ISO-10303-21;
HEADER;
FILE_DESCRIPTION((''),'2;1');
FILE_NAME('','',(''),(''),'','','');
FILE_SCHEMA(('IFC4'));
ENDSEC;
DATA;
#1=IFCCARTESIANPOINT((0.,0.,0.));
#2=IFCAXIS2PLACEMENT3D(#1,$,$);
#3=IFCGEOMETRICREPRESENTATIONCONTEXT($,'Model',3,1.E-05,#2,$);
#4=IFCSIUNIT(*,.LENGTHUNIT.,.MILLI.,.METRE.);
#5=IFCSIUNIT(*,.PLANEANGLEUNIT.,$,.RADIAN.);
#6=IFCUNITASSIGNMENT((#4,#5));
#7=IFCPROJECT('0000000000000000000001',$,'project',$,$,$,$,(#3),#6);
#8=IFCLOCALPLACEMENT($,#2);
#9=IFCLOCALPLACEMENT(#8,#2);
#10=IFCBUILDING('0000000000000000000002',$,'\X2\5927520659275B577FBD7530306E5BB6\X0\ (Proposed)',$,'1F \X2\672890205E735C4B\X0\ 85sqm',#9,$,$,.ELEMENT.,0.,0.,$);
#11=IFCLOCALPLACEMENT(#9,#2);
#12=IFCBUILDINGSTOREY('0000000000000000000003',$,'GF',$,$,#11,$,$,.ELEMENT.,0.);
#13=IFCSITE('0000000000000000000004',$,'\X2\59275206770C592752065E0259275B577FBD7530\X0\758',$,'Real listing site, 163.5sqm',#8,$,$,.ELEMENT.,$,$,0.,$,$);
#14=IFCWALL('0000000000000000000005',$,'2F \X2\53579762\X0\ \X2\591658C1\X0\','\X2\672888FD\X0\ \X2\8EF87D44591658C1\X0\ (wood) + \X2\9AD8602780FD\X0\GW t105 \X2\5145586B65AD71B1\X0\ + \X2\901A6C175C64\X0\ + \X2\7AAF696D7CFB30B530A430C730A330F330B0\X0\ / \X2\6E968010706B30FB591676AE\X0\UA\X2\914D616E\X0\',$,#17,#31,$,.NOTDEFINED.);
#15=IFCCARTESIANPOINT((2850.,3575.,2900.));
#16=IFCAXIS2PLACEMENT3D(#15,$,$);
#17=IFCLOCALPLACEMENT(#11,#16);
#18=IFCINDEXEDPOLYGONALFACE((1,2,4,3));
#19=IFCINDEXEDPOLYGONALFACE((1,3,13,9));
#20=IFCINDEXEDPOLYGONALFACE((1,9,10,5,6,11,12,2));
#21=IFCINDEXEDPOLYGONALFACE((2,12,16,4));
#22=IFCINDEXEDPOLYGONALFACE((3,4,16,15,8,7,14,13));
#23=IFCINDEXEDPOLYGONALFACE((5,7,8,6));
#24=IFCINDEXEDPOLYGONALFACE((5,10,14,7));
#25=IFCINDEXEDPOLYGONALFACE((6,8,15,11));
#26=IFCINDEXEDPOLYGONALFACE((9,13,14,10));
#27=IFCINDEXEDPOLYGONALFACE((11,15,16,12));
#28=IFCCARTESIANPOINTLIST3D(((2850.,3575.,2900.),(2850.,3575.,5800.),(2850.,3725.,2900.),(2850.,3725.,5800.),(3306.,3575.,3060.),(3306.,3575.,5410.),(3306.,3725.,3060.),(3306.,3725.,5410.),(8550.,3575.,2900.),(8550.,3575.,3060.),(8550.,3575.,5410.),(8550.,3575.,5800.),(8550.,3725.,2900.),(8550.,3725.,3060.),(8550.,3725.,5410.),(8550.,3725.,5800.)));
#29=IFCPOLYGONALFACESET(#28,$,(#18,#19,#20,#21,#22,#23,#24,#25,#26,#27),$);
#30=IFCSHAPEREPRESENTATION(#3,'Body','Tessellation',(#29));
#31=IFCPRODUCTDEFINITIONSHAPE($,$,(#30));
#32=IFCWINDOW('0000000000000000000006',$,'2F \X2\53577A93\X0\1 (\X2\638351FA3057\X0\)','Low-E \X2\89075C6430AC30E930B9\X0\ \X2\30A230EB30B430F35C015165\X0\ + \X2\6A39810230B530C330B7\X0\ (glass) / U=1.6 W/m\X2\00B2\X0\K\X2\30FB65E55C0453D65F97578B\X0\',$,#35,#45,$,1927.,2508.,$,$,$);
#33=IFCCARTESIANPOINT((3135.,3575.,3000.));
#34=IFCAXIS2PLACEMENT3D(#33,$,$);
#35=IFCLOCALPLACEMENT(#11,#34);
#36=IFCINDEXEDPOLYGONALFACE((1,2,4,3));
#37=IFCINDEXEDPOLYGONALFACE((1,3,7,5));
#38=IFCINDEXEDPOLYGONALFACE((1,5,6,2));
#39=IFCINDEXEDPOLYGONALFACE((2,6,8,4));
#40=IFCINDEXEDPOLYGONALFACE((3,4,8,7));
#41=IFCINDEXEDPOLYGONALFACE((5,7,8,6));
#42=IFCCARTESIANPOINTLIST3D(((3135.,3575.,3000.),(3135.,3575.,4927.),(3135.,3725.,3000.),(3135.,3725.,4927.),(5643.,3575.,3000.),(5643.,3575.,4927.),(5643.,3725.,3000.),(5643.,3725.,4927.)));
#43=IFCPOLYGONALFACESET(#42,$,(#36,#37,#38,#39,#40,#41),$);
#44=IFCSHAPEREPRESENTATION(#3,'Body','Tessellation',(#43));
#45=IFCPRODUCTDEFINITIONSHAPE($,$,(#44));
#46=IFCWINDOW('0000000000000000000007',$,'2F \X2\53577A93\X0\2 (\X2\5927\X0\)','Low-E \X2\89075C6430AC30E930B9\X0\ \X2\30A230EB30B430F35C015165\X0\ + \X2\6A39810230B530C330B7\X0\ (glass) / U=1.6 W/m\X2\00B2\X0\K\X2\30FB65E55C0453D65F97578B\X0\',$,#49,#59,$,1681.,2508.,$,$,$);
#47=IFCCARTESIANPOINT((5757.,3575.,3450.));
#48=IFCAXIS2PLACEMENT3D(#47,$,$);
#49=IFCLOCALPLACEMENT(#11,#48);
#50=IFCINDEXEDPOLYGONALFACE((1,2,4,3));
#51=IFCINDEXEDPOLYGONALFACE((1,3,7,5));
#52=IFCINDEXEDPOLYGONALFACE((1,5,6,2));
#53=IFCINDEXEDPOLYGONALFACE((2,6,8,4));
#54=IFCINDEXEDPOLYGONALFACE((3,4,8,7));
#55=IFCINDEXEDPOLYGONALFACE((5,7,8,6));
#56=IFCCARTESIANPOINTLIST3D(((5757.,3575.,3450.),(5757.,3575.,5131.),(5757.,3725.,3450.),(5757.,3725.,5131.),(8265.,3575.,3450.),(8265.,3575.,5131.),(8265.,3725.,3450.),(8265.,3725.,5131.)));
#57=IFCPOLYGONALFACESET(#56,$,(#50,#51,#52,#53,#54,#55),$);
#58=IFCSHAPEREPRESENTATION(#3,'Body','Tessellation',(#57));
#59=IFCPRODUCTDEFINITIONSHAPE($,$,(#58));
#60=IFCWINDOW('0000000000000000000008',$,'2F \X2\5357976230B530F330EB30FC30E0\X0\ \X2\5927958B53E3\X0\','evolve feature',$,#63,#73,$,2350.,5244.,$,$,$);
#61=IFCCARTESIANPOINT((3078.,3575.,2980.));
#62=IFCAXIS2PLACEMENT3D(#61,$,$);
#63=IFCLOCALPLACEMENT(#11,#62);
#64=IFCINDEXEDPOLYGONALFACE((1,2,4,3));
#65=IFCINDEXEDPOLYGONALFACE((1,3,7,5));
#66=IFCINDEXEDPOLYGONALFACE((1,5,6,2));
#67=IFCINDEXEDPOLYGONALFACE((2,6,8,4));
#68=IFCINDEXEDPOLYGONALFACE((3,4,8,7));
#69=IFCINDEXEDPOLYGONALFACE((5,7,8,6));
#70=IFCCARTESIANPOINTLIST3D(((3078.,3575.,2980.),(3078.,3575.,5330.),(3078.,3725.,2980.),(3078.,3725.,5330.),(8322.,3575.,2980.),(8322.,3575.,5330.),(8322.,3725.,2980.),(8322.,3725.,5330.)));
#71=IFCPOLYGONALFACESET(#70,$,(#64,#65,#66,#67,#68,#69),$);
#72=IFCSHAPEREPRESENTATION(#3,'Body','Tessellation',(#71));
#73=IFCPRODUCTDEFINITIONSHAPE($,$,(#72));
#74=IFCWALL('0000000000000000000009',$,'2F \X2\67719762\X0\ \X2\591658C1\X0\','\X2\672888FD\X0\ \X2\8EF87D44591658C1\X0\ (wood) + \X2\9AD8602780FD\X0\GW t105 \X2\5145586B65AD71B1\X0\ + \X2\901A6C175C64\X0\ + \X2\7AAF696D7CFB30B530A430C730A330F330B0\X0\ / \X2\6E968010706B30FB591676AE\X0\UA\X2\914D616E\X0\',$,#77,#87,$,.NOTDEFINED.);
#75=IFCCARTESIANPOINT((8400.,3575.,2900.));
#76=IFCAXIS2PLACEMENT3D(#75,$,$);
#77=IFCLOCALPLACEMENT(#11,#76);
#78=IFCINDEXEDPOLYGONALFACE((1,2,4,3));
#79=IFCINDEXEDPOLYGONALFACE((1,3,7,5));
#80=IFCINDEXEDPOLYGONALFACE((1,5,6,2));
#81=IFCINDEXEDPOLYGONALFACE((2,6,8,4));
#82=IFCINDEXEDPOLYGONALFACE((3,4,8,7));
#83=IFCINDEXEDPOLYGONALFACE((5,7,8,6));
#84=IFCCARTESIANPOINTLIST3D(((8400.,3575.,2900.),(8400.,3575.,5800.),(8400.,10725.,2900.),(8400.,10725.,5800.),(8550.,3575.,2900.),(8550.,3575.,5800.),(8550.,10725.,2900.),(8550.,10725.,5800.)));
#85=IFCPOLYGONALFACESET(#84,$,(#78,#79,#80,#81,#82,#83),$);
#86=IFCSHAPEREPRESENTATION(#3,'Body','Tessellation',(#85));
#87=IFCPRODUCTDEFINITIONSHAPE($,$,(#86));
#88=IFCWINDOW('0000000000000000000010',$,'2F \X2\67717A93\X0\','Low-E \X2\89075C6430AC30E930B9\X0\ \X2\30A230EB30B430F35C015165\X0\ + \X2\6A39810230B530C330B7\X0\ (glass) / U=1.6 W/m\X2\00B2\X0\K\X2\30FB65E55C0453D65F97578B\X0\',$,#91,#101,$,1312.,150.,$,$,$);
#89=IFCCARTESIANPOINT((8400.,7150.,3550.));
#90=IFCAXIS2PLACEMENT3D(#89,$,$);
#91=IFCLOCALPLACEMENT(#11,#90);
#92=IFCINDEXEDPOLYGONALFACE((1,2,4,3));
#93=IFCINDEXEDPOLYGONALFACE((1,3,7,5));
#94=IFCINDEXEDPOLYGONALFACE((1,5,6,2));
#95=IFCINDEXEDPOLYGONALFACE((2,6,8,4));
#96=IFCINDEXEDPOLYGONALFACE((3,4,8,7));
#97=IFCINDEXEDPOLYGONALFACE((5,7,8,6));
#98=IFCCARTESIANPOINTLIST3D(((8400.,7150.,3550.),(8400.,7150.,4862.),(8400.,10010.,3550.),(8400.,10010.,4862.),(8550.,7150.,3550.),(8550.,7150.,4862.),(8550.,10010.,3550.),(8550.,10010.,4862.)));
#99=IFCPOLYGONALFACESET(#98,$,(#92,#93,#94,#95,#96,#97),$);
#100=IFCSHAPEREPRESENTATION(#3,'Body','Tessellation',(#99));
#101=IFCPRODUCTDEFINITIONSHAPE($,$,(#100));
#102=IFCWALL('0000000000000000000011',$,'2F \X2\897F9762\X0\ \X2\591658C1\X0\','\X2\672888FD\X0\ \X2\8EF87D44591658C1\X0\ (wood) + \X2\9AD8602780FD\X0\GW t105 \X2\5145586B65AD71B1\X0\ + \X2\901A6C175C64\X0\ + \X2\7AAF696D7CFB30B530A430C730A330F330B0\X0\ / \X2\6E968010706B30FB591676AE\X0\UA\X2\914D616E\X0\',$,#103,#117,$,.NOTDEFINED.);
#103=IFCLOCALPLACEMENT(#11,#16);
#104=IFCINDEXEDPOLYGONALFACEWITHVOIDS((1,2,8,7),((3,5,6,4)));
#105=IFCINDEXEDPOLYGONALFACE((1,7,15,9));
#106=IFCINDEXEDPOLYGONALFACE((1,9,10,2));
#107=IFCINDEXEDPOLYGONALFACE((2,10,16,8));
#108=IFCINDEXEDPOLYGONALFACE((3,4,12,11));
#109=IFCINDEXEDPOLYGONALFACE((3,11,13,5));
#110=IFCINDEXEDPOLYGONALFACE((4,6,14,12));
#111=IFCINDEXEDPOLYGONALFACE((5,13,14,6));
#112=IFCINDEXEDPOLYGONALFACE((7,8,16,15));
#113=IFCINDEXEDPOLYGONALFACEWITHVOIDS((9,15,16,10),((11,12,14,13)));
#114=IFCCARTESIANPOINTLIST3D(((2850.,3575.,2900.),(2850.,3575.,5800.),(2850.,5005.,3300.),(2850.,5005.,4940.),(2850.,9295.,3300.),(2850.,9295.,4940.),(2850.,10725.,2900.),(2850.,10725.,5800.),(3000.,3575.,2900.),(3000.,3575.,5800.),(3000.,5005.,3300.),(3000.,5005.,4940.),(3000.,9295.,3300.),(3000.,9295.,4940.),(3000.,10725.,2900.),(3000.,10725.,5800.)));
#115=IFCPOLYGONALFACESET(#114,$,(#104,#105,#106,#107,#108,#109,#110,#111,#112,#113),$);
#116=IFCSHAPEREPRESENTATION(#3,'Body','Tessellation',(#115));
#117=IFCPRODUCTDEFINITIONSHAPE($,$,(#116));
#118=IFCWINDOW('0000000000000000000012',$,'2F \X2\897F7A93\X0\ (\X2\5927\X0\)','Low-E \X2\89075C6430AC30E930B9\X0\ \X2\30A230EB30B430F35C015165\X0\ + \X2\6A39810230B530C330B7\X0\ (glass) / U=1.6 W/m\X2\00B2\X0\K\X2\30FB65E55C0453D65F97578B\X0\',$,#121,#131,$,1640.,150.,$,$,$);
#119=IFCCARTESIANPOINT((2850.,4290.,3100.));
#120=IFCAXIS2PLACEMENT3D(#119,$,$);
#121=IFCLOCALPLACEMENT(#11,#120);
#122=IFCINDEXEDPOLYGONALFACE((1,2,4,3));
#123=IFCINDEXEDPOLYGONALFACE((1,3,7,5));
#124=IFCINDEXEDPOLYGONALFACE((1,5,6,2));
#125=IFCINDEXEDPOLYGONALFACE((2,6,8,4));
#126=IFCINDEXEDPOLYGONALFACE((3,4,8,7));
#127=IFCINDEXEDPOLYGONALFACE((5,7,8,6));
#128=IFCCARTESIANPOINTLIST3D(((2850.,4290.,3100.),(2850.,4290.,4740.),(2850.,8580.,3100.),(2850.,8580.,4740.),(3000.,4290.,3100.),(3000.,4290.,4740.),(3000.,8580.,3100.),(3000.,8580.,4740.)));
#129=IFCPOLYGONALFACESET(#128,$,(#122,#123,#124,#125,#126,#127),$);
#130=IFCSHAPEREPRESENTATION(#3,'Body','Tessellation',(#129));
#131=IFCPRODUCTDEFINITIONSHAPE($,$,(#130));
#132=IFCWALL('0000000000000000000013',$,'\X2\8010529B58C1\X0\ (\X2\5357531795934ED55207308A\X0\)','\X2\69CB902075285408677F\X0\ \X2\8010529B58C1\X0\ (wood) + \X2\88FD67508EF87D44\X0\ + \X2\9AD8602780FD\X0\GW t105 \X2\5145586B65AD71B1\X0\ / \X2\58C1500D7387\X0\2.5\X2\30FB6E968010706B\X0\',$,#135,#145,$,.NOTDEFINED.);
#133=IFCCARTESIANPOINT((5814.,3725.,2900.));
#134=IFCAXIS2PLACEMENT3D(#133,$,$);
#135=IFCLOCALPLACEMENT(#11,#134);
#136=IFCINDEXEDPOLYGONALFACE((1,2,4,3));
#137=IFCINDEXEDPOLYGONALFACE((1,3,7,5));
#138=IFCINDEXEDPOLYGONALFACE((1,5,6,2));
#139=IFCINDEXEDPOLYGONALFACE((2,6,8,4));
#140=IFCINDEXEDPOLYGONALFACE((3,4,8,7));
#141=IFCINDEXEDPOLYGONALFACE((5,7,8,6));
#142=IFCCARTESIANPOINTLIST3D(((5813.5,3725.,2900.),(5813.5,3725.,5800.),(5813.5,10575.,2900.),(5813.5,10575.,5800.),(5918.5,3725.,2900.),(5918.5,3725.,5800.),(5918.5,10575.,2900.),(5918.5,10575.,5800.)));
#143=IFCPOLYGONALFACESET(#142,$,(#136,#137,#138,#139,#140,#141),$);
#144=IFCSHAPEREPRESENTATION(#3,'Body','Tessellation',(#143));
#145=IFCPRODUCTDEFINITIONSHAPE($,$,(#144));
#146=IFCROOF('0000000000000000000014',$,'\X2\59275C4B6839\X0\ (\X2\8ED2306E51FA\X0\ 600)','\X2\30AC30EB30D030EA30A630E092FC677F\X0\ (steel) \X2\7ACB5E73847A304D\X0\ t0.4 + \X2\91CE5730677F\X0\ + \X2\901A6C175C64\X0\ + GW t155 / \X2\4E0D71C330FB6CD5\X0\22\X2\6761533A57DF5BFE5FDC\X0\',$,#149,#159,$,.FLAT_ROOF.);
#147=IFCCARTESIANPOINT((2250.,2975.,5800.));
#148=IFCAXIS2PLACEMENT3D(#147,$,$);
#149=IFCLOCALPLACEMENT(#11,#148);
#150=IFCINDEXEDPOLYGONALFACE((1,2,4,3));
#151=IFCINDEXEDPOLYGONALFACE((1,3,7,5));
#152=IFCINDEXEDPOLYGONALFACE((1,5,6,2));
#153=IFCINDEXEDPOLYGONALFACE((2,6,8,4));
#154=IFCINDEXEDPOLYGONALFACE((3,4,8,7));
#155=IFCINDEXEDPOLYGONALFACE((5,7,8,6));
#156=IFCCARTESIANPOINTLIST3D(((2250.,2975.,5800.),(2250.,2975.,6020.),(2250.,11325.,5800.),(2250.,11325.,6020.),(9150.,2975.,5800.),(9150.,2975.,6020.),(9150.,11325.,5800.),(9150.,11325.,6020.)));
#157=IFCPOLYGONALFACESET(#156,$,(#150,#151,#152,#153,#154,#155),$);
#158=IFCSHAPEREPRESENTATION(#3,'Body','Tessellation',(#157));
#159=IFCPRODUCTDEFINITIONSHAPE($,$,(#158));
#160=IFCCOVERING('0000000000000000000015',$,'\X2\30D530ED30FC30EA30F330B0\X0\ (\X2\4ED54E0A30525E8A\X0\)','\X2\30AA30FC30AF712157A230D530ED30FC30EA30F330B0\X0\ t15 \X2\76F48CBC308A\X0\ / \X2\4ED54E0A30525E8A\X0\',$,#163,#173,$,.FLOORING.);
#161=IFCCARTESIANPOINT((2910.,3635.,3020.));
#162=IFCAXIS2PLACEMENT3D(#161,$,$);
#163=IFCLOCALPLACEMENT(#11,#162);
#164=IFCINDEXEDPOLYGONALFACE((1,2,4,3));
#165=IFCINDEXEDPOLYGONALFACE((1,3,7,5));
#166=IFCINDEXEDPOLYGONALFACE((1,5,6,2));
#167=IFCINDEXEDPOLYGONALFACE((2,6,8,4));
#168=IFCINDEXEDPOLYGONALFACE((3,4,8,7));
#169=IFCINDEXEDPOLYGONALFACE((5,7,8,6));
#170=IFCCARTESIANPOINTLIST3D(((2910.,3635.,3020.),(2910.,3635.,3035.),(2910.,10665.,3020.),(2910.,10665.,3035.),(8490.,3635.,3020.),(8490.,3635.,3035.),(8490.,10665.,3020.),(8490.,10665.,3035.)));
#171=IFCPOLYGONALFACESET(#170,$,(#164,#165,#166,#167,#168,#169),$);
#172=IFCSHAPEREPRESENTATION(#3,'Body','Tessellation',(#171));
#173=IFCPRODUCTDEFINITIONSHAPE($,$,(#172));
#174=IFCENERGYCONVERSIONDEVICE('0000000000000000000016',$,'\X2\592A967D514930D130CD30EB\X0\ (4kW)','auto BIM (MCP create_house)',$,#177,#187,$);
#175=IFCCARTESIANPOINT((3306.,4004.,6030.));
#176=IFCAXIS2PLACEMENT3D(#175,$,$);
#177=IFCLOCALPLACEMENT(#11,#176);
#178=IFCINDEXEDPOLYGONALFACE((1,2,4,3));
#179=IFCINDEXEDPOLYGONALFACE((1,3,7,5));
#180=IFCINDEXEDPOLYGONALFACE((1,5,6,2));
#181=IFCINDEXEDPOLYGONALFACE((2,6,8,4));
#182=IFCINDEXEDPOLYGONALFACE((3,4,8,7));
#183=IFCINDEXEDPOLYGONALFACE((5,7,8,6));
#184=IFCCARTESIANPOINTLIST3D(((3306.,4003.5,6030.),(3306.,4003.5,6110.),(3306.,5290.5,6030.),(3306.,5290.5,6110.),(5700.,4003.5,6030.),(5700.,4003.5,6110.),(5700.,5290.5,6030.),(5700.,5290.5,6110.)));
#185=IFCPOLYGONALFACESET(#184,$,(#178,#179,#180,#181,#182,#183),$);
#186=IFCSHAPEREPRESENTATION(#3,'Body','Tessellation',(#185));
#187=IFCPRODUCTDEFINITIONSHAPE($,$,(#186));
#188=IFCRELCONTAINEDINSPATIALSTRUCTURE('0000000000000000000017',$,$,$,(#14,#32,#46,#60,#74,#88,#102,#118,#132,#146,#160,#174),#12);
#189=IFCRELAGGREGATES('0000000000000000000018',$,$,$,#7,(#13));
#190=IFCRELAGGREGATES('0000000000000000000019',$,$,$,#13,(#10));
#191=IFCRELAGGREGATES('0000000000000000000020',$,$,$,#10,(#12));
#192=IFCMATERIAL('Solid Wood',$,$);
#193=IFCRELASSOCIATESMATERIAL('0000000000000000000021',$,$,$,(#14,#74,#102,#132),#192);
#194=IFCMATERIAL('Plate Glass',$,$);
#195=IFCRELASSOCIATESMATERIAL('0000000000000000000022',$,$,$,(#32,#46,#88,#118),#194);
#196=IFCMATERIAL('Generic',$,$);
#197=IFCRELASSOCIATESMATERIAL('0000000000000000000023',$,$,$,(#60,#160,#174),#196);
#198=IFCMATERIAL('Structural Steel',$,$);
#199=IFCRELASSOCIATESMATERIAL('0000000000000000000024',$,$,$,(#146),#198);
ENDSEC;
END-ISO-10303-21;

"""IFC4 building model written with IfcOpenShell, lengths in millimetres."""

from ifc_helpers import new_model, si_unit, frame, frame_2d, origin, place, context, project, spatial, rectangle, extrude, material, element, fill, save


model = new_model("IFC4")

# Units and contexts
model_context = context("Model", 3, precision=1e-05, world=origin())
ifc_project = project(units=[si_unit("LENGTHUNIT", "METRE", prefix="MILLI"), si_unit("PLANEANGLEUNIT", "RADIAN")], contexts=[model_context])

# Site, building, storey
site_placement = place(None, origin())
site = spatial("IfcSite", under=ifc_project, at=site_placement, Name="大分県大分市大字羽田758", ObjectType="Real listing site, 163.5sqm", CompositionType="ELEMENT", RefElevation=0.0)
building_placement = place(site_placement, origin())
building = spatial("IfcBuilding", under=site, at=building_placement, Name="大分大字羽田の家 (Proposed)", ObjectType="1F 木造平屋 85sqm", CompositionType="ELEMENT", ElevationOfRefHeight=0.0, ElevationOfTerrain=0.0)
storey_placement = place(building_placement, origin())
storey = spatial("IfcBuildingStorey", under=building, at=storey_placement, Name="GF", CompositionType="ELEMENT", Elevation=0.0)

# Shared definitions
ifc_material_1 = material(Name="Solid Wood")

# Wall, openings, windows
wall_1_placement = place(storey_placement, frame((2850.0, 3575.0, 2900.0)))
wall_1 = element("IfcWall", 1, at=wall_1_placement, inside=storey, material=ifc_material_1, Name="2F 南面 外壁", Description="木製 軸組外壁 (wood) + 高性能GW t105 充填断熱 + 通気層 + 窯業系サイディング / 準耐火・外皮UA配慮", PredefinedType="NOTDEFINED", context=model_context, shape_type="SweptSolid", body=[
    extrude(rectangle(XDim=5700.0, YDim=150.0, at=frame_2d((2850.0, 75.0))), frame((2850.0, 3575.0, 2900.0)), (0.0, 0.0, 1.0), 2900.0),
])
opening_1_placement = place(storey_placement, frame((3135.0, 3575.0, 3000.0)))
opening_1 = element("IfcOpeningElement", 2, at=opening_1_placement, cuts=wall_1, PredefinedType="NOTDEFINED", context=model_context, shape_type="SweptSolid", body=[
    extrude(rectangle(XDim=2508.0, YDim=150.0, at=frame_2d((1254.0, 75.0))), frame((3135.0, 3575.0, 3000.0)), (0.0, 0.0, 1.0), 1927.0),
])
opening_2_placement = place(storey_placement, frame((5757.0, 3575.0, 3450.0)))
opening_2 = element("IfcOpeningElement", 3, at=opening_2_placement, cuts=wall_1, PredefinedType="NOTDEFINED", context=model_context, shape_type="SweptSolid", body=[
    extrude(rectangle(XDim=2508.0, YDim=150.0, at=frame_2d((1254.0, 75.0))), frame((5757.0, 3575.0, 3450.0)), (0.0, 0.0, 1.0), 1681.0),
])
opening_3_placement = place(storey_placement, frame((3078.0, 3575.0, 2980.0)))
opening_3 = element("IfcOpeningElement", 4, at=opening_3_placement, cuts=wall_1, PredefinedType="NOTDEFINED", context=model_context, shape_type="SweptSolid", body=[
    extrude(rectangle(XDim=5244.0, YDim=150.0, at=frame_2d((2622.0, 75.0))), frame((3078.0, 3575.0, 2980.0)), (0.0, 0.0, 1.0), 2350.0),
])
ifc_material_2 = material(Name="Plate Glass")
window_1_placement = place(storey_placement, frame((3135.0, 3575.0, 3000.0)))
window_1 = element("IfcWindow", 5, at=window_1_placement, inside=storey, material=ifc_material_2, Name="2F 南窓1 (掃出し)", Description="Low-E 複層ガラス アルゴン封入 + 樹脂サッシ (glass) / U=1.6 W/m²K・日射取得型", OverallHeight=1927.0, OverallWidth=2508.0, context=model_context, shape_type="SweptSolid", body=[
    extrude(rectangle(XDim=2508.0, YDim=150.0, at=frame_2d((1254.0, 75.0))), frame((3135.0, 3575.0, 3000.0)), (0.0, 0.0, 1.0), 1927.0),
])
fill(opening_1, window_1)
window_2_placement = place(storey_placement, frame((5757.0, 3575.0, 3450.0)))
window_2 = element("IfcWindow", 6, at=window_2_placement, inside=storey, material=ifc_material_2, Name="2F 南窓2 (大)", Description="Low-E 複層ガラス アルゴン封入 + 樹脂サッシ (glass) / U=1.6 W/m²K・日射取得型", OverallHeight=1681.0, OverallWidth=2508.0, context=model_context, shape_type="SweptSolid", body=[
    extrude(rectangle(XDim=2508.0, YDim=150.0, at=frame_2d((1254.0, 75.0))), frame((5757.0, 3575.0, 3450.0)), (0.0, 0.0, 1.0), 1681.0),
])
fill(opening_2, window_2)
ifc_material_3 = material(Name="Generic")
window_3_placement = place(storey_placement, frame((3078.0, 3575.0, 2980.0)))
window_3 = element("IfcWindow", 7, at=window_3_placement, inside=storey, material=ifc_material_3, Name="2F 南面サンルーム 大開口", Description="evolve feature", OverallHeight=2350.0, OverallWidth=5244.0, context=model_context, shape_type="SweptSolid", body=[
    extrude(rectangle(XDim=5244.0, YDim=150.0, at=frame_2d((2622.0, 75.0))), frame((3078.0, 3575.0, 2980.0)), (0.0, 0.0, 1.0), 2350.0),
])
fill(opening_3, window_3)

# Walls, openings, windows
wall_2_placement = place(storey_placement, frame((8400.0, 3575.0, 2900.0)))
wall_2 = element("IfcWall", 8, at=wall_2_placement, inside=storey, material=ifc_material_1, Name="2F 東面 外壁", Description="木製 軸組外壁 (wood) + 高性能GW t105 充填断熱 + 通気層 + 窯業系サイディング / 準耐火・外皮UA配慮", PredefinedType="NOTDEFINED", context=model_context, shape_type="SweptSolid", body=[
    extrude(rectangle(XDim=150.0, YDim=7150.0, at=frame_2d((75.0, 3575.0))), frame((8400.0, 3575.0, 2900.0)), (0.0, 0.0, 1.0), 2900.0),
])
opening_4_placement = place(storey_placement, frame((8400.0, 7150.0, 3550.0)))
opening_4 = element("IfcOpeningElement", 9, at=opening_4_placement, cuts=wall_2, PredefinedType="NOTDEFINED", context=model_context, shape_type="SweptSolid", body=[
    extrude(rectangle(XDim=150.0, YDim=2860.0, at=frame_2d((75.0, 1430.0))), frame((8400.0, 7150.0, 3550.0)), (0.0, 0.0, 1.0), 1312.0),
])
window_4_placement = place(storey_placement, frame((8400.0, 7150.0, 3550.0)))
window_4 = element("IfcWindow", 10, at=window_4_placement, inside=storey, material=ifc_material_2, Name="2F 東窓", Description="Low-E 複層ガラス アルゴン封入 + 樹脂サッシ (glass) / U=1.6 W/m²K・日射取得型", OverallHeight=1312.0, OverallWidth=150.0, context=model_context, shape_type="SweptSolid", body=[
    extrude(rectangle(XDim=150.0, YDim=2860.0, at=frame_2d((75.0, 1430.0))), frame((8400.0, 7150.0, 3550.0)), (0.0, 0.0, 1.0), 1312.0),
])
fill(opening_4, window_4)
wall_3_placement = place(storey_placement, frame((2850.0, 3575.0, 2900.0)))
wall_3 = element("IfcWall", 11, at=wall_3_placement, inside=storey, material=ifc_material_1, Name="2F 西面 外壁", Description="木製 軸組外壁 (wood) + 高性能GW t105 充填断熱 + 通気層 + 窯業系サイディング / 準耐火・外皮UA配慮", PredefinedType="NOTDEFINED", context=model_context, shape_type="SweptSolid", body=[
    extrude(rectangle(XDim=150.0, YDim=7150.0, at=frame_2d((75.0, 3575.0))), frame((2850.0, 3575.0, 2900.0)), (0.0, 0.0, 1.0), 2900.0),
])
opening_5_placement = place(storey_placement, frame((2850.0, 4290.0, 3100.0)))
opening_5 = element("IfcOpeningElement", 12, at=opening_5_placement, cuts=wall_3, PredefinedType="NOTDEFINED", context=model_context, shape_type="SweptSolid", body=[
    extrude(rectangle(XDim=150.0, YDim=4290.0, at=frame_2d((75.0, 2145.0))), frame((2850.0, 4290.0, 3100.0)), (0.0, 0.0, 1.0), 1640.0),
])
window_5_placement = place(storey_placement, frame((2850.0, 4290.0, 3100.0)))
window_5 = element("IfcWindow", 13, at=window_5_placement, inside=storey, material=ifc_material_2, Name="2F 西窓 (大)", Description="Low-E 複層ガラス アルゴン封入 + 樹脂サッシ (glass) / U=1.6 W/m²K・日射取得型", OverallHeight=1640.0, OverallWidth=150.0, context=model_context, shape_type="SweptSolid", body=[
    extrude(rectangle(XDim=150.0, YDim=4290.0, at=frame_2d((75.0, 2145.0))), frame((2850.0, 4290.0, 3100.0)), (0.0, 0.0, 1.0), 1640.0),
])
fill(opening_5, window_5)

# Wall
wall_4_placement = place(storey_placement, frame((5814.0, 3725.0, 2900.0)))
element("IfcWall", 14, at=wall_4_placement, inside=storey, material=ifc_material_1, Name="耐力壁 (南北間仕切り)", Description="構造用合板 耐力壁 (wood) + 製材軸組 + 高性能GW t105 充填断熱 / 壁倍率2.5・準耐火", PredefinedType="NOTDEFINED", context=model_context, shape_type="SweptSolid", body=[
    extrude(rectangle(XDim=105.0, YDim=6850.0, at=frame_2d((52.0, 3425.0))), frame((5814.0, 3725.0, 2900.0)), (0.0, 0.0, 1.0), 2900.0),
])

# Roof
ifc_material_4 = material(Name="Structural Steel")
roof_placement = place(storey_placement, frame((2250.0, 2975.0, 5800.0)))
element("IfcRoof", 15, at=roof_placement, inside=storey, material=ifc_material_4, Name="大屋根 (軒の出 600)", Description="ガルバリウム鋼板 (steel) 立平葺き t0.4 + 野地板 + 通気層 + GW t155 / 不燃・法22条区域対応", PredefinedType="FLAT_ROOF", context=model_context, shape_type="SweptSolid", body=[
    extrude(rectangle(XDim=6900.0, YDim=8350.0, at=frame_2d((3450.0, 4175.0))), frame((2250.0, 2975.0, 5800.0)), (0.0, 0.0, 1.0), 220.0),
])

# Covering
covering_placement = place(storey_placement, frame((2910.0, 3635.0, 3020.0)))
element("IfcCovering", 16, at=covering_placement, inside=storey, material=ifc_material_3, Name="フローリング (仕上げ床)", Description="オーク無垢フローリング t15 直貼り / 仕上げ床", PredefinedType="FLOORING", context=model_context, shape_type="SweptSolid", body=[
    extrude(rectangle(XDim=5580.0, YDim=7030.0, at=frame_2d((2790.0, 3515.0))), frame((2910.0, 3635.0, 3020.0)), (0.0, 0.0, 1.0), 15.0),
])

# Energy conversion device
energy_conversion_device_placement = place(storey_placement, frame((3306.0, 4004.0, 6030.0)))
element("IfcEnergyConversionDevice", 17, at=energy_conversion_device_placement, inside=storey, material=ifc_material_3, Name="太陽光パネル (4kW)", Description="auto BIM (MCP create_house)", context=model_context, shape_type="SweptSolid", body=[
    extrude(rectangle(XDim=2394.0, YDim=1287.0, at=frame_2d((1197.0, 643.0))), frame((3306.0, 4004.0, 6030.0)), (0.0, 0.0, 1.0), 80.0),
])

save(model, "model.ifc")
